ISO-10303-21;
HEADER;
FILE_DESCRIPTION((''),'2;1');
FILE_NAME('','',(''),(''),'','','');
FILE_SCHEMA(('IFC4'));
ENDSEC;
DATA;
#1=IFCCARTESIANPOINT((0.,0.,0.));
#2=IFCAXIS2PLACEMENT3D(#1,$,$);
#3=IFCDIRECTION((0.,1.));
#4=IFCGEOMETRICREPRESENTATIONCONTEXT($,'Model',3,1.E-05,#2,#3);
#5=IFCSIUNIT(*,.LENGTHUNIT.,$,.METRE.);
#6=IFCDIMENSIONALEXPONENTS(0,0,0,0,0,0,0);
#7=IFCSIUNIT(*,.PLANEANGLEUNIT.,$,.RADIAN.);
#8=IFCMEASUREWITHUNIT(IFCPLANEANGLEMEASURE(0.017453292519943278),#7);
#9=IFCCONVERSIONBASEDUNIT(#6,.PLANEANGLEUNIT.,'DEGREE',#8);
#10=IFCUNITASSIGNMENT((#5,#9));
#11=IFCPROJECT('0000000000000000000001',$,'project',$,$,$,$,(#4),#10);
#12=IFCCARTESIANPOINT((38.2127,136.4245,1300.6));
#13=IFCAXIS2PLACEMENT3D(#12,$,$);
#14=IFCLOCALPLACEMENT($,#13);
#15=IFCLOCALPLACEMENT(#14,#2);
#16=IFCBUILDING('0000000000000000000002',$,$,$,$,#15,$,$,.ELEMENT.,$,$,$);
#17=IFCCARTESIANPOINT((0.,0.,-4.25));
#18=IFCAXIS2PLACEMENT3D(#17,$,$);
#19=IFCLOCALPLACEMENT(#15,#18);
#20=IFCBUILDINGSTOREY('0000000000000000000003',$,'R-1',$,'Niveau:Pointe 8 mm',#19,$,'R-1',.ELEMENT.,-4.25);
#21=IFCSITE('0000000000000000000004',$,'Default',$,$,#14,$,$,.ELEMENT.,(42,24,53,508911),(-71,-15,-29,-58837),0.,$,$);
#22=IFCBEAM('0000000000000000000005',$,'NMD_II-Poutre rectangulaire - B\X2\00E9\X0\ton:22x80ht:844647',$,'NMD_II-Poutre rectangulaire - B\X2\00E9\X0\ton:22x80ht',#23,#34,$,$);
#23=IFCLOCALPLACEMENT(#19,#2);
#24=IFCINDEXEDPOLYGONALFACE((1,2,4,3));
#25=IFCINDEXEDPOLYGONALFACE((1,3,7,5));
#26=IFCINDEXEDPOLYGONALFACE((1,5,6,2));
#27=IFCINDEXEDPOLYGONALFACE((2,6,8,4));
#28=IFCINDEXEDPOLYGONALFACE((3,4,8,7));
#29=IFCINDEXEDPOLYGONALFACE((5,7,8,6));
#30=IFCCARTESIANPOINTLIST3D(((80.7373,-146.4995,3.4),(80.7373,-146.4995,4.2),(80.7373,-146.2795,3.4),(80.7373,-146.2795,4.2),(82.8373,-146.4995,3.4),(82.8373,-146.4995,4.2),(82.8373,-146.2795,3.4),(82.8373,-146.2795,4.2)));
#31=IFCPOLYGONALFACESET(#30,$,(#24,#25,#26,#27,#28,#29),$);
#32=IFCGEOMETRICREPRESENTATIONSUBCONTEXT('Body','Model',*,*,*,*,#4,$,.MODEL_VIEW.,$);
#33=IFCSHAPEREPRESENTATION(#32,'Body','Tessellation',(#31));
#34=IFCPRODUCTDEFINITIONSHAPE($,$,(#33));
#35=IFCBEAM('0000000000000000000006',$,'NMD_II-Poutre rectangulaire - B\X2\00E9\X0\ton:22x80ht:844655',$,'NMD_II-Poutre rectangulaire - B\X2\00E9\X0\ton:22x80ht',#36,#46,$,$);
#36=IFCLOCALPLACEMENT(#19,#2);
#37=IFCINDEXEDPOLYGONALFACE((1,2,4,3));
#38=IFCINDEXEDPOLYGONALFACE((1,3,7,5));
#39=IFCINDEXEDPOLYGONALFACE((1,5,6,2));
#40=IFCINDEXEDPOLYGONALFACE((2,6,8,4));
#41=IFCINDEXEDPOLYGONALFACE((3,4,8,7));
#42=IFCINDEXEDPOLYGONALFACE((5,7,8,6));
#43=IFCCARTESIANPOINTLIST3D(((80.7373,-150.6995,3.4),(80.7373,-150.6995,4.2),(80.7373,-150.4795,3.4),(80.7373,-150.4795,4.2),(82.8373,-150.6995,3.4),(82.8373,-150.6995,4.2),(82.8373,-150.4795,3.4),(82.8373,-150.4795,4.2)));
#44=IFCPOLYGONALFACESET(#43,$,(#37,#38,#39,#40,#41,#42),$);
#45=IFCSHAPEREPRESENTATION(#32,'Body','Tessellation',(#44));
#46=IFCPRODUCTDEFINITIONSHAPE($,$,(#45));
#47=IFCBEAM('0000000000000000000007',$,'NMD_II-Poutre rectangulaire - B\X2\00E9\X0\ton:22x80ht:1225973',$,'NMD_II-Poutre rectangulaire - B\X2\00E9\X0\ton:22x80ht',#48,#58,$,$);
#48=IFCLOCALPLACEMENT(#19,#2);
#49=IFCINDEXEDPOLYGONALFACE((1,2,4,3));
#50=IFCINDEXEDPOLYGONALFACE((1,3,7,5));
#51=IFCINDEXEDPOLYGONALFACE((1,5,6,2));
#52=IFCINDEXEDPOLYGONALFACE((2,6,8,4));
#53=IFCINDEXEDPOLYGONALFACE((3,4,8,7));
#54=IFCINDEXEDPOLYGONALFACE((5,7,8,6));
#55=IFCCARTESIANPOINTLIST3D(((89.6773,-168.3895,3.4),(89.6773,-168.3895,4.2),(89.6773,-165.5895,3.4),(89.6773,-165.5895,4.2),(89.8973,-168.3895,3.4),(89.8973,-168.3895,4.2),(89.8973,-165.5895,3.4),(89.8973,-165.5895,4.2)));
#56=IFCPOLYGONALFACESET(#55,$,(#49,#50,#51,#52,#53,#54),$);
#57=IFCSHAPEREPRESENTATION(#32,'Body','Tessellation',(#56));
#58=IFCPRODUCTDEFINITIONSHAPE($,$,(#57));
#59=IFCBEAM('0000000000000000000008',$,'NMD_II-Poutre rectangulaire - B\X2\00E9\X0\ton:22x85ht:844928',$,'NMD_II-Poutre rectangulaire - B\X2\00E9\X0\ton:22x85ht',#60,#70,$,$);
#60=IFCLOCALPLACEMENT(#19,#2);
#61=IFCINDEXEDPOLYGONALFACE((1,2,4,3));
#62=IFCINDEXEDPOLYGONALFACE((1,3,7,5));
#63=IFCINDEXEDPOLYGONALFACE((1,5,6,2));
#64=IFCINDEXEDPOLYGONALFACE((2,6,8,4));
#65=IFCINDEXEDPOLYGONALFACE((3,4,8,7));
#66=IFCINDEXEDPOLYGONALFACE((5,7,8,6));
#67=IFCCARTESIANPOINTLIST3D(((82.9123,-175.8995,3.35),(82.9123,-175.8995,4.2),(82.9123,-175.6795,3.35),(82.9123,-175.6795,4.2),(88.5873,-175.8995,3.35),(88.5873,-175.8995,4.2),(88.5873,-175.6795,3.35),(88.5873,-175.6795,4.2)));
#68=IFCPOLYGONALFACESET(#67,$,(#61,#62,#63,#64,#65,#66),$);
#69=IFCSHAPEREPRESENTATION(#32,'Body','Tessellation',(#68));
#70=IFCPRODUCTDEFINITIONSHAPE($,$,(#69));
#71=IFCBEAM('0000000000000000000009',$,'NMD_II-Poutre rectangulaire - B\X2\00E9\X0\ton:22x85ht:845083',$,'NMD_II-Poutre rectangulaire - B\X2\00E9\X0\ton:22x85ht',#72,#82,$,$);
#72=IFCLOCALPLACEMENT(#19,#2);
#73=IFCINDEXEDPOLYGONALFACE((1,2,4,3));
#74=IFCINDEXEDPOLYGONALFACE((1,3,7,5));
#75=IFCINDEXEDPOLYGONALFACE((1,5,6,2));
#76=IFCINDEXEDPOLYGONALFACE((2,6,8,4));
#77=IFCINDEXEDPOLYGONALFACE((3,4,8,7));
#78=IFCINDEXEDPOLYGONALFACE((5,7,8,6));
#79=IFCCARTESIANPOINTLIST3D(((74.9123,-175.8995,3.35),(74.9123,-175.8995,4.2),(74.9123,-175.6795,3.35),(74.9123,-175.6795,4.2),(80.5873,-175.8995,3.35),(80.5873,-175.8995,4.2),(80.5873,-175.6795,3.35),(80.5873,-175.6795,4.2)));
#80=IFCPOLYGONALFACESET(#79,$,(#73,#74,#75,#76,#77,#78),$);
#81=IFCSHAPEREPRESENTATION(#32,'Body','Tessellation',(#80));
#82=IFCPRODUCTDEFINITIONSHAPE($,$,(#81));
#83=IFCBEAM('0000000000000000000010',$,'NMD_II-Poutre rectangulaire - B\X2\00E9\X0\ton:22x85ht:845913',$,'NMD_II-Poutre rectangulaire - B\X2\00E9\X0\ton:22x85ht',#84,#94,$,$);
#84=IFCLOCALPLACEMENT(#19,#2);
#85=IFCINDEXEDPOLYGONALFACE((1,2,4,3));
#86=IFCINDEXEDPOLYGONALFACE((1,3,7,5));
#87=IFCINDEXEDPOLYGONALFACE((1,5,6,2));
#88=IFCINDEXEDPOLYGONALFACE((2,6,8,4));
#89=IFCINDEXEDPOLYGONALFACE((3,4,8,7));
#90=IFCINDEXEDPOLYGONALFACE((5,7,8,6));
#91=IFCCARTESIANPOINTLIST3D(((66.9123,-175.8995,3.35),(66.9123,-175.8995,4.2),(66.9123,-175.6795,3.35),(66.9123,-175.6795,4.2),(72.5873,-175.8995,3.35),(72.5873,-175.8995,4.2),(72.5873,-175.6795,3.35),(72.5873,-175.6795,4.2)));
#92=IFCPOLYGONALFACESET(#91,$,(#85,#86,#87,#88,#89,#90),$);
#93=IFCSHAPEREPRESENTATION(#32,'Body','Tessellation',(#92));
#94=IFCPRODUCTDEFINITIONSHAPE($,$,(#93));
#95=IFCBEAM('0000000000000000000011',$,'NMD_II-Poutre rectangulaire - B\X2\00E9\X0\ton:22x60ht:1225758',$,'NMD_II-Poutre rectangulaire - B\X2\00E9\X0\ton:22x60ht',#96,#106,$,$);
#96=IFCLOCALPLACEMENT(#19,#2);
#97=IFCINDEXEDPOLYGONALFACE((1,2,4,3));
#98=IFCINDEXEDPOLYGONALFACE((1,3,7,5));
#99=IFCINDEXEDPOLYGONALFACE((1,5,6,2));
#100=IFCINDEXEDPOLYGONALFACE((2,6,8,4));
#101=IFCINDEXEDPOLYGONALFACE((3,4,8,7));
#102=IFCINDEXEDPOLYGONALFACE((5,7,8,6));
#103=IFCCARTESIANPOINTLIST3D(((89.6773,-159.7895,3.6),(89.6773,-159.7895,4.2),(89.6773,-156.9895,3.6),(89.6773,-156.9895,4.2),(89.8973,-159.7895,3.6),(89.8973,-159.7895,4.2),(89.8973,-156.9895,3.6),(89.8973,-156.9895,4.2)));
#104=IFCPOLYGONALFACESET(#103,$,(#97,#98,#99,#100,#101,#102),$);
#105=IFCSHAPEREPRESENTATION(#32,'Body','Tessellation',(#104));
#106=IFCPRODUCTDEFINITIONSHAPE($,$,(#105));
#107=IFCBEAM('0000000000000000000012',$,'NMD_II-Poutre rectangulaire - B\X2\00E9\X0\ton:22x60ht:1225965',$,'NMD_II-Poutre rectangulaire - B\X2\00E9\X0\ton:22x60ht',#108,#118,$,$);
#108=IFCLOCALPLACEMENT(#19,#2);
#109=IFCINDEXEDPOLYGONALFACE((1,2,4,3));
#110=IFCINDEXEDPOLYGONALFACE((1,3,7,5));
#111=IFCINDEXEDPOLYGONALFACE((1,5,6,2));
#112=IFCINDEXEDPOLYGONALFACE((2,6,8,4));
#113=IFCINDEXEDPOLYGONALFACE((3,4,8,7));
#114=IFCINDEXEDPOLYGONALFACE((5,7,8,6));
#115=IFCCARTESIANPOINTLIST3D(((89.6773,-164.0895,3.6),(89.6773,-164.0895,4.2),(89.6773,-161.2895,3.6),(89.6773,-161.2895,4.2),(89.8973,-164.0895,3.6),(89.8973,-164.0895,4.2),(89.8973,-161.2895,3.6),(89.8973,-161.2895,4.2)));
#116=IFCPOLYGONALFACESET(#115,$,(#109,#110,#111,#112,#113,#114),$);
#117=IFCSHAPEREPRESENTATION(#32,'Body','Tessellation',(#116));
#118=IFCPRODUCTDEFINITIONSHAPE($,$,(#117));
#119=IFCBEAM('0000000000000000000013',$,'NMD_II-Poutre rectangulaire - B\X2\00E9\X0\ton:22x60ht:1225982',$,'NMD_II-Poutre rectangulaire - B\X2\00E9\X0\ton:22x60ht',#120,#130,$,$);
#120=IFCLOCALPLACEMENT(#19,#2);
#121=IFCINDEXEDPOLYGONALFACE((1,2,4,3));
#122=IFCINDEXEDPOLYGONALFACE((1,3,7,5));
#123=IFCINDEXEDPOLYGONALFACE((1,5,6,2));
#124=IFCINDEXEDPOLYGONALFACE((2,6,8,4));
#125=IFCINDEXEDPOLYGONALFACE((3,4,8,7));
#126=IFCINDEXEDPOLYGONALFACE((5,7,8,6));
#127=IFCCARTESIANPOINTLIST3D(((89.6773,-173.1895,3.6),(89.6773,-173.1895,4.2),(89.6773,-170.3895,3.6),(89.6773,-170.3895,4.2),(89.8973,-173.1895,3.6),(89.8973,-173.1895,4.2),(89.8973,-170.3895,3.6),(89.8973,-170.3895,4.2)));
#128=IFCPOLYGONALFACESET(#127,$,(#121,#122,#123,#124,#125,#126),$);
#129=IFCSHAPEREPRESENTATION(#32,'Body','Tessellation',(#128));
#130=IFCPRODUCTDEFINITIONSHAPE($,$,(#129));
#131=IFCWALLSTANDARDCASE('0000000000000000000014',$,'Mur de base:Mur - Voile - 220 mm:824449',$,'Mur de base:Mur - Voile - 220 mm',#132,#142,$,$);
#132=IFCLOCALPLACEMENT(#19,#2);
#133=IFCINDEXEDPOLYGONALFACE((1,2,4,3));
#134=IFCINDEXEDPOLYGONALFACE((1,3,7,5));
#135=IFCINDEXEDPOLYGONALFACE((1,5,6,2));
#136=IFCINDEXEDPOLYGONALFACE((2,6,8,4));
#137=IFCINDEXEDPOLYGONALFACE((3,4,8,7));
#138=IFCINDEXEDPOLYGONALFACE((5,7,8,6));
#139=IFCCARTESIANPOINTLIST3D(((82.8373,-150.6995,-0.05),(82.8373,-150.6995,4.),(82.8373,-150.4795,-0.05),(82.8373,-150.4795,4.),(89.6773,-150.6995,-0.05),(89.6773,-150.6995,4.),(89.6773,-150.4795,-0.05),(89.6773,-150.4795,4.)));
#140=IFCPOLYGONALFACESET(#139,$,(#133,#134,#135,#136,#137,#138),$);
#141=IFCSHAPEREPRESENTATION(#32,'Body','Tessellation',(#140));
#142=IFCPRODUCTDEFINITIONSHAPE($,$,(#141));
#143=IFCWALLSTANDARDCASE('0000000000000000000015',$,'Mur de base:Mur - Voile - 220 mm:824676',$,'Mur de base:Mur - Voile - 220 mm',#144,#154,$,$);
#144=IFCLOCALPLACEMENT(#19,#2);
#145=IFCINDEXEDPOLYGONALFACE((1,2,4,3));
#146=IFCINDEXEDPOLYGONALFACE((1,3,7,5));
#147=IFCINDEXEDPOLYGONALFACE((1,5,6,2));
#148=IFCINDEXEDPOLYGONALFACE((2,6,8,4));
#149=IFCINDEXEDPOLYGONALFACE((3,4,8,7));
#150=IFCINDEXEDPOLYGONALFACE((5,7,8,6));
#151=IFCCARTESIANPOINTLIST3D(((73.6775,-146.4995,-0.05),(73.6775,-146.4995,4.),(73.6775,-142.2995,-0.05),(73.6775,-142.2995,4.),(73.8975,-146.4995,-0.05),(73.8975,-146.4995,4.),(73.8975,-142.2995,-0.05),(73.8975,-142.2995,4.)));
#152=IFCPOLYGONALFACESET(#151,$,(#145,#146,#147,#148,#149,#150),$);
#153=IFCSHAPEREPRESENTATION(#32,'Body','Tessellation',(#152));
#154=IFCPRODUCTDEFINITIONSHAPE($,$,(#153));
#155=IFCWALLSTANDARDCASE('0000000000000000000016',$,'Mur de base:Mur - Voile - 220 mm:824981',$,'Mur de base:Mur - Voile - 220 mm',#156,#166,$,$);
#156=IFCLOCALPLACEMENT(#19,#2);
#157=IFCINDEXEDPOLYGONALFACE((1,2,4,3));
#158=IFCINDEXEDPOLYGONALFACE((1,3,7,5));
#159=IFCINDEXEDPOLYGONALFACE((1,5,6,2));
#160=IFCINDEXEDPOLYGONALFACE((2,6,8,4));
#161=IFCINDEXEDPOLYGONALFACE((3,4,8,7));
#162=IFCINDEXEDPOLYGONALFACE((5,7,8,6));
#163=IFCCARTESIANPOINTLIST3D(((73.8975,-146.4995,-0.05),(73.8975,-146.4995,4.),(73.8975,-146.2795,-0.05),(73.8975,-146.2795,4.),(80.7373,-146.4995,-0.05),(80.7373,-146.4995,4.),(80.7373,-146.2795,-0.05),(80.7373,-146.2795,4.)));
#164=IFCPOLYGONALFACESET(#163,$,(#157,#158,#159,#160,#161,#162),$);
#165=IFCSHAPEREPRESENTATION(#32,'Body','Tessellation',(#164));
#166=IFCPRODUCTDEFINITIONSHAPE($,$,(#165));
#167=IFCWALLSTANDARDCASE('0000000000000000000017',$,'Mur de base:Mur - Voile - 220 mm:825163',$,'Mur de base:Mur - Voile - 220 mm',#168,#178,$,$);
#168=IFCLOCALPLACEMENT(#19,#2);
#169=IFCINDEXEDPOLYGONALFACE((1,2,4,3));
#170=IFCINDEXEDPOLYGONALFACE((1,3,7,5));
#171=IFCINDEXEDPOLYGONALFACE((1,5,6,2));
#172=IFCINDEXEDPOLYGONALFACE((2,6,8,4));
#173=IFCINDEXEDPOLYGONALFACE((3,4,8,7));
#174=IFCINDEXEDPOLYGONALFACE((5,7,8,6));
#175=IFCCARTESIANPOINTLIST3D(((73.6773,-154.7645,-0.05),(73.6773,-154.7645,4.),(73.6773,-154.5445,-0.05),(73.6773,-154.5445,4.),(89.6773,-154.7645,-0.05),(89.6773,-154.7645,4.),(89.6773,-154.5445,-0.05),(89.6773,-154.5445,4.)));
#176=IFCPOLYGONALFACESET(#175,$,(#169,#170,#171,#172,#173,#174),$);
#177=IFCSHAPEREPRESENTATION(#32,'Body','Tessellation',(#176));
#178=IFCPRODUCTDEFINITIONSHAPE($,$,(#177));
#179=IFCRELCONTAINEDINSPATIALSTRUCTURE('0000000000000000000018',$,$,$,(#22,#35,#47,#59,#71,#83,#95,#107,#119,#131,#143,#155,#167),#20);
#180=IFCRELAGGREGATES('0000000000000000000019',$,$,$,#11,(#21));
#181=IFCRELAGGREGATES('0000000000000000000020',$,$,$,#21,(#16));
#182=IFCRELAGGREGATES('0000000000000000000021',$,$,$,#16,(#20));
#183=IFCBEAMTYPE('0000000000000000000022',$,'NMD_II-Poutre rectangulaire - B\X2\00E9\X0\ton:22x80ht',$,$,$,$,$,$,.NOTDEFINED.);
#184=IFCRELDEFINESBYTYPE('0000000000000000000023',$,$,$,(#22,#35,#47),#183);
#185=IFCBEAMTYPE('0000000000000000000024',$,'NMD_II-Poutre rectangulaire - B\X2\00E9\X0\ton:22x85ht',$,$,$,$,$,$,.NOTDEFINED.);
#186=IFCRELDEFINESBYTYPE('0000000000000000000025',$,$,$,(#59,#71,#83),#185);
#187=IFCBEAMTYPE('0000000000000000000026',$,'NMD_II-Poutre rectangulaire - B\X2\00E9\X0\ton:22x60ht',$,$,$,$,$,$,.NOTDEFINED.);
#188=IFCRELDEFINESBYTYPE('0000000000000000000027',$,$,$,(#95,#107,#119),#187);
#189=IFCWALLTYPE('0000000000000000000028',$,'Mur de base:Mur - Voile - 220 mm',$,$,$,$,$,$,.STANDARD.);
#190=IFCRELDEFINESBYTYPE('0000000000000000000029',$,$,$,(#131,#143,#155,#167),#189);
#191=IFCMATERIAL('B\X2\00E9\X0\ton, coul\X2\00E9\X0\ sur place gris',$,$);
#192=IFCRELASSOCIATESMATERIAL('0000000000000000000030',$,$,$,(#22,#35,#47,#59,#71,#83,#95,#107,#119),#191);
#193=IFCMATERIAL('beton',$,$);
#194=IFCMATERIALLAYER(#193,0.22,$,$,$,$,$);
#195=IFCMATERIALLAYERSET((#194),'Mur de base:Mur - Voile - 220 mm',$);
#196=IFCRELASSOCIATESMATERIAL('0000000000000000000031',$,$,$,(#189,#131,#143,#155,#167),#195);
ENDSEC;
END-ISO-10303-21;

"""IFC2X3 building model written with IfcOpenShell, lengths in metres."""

from ifc_helpers import new_model, entity, si_unit, converted_unit, direction, frame, frame_2d, origin, origin_2d_with_axis, place, context, subcontext, project, spatial, polyline, rectangle, extrude, clip, bounded_halfspace, material, layer, layer_set, layer_usage, type_object, element, save


model = new_model("IFC2X3")

# Units and contexts
model_context = context("Model", 3, precision=1e-05, world=origin(), true_north=direction((0.0, 1.0)))
body_context = subcontext(model_context, "Body", "Model", "MODEL_VIEW")
ifc_project = project(units=[si_unit("LENGTHUNIT", "METRE"), converted_unit("PLANEANGLEUNIT", "DEGREE", entity("IfcPlaneAngleMeasure", 0.017453292519943278), si_unit("PLANEANGLEUNIT", "RADIAN"), dimensions=[0, 0, 0, 0, 0, 0, 0])], contexts=[model_context])

# Site, building, storey
site_placement = place(None, frame((38.2127, 136.4245, 1300.6)))
site = spatial("IfcSite", under=ifc_project, at=site_placement, Name="Default", CompositionType="ELEMENT", RefLatitude=(42, 24, 53, 508911), RefLongitude=(-71, -15, -29, -58837), RefElevation=0.0)
building_placement = place(site_placement, origin())
building = spatial("IfcBuilding", under=site, at=building_placement, CompositionType="ELEMENT")
storey_placement = place(building_placement, frame((0.0, 0.0, -4.25)))
storey = spatial("IfcBuildingStorey", under=building, at=storey_placement, Name="R-1", ObjectType="Niveau:Pointe 8 mm", LongName="R-1", CompositionType="ELEMENT", Elevation=-4.25)

# Beams
ifc_material_1 = material(Name="Béton, coulé sur place gris")
beam_type_1 = type_object("IfcBeamType", Name="NMD_II-Poutre rectangulaire - Béton:22x80ht", PredefinedType="NOTDEFINED")
for number, where, name in (
    (1, (80.7373, -146.3895, 4.2), "NMD_II-Poutre rectangulaire - Béton:22x80ht:844647"),
    (2, (80.7373, -150.5895, 4.2), "NMD_II-Poutre rectangulaire - Béton:22x80ht:844655"),
):
    element("IfcBeam", number, at=place(storey_placement, frame(where)), inside=storey, type_object=beam_type_1, material=ifc_material_1, Name=name, ObjectType="NMD_II-Poutre rectangulaire - Béton:22x80ht", context=body_context, shape_type="SweptSolid", body=[
        extrude(rectangle(XDim=0.8, YDim=0.22, at=origin_2d_with_axis()), frame((0.0, 0.0, -0.4), z_axis=(1.0, 0.0, 0.0), x_axis=(0.0, 0.0, -1.0)), (0.0, 0.0, 1.0), 2.1),
    ])
beam_1_placement = place(storey_placement, frame((89.7873, -168.3895, 4.2), z_axis=(0.0, 0.0, 1.0), x_axis=(0.0, 1.0, 0.0)))
element("IfcBeam", 3, at=beam_1_placement, inside=storey, type_object=beam_type_1, material=ifc_material_1, Name="NMD_II-Poutre rectangulaire - Béton:22x80ht:1225973", ObjectType="NMD_II-Poutre rectangulaire - Béton:22x80ht", context=body_context, shape_type="SweptSolid", body=[
    extrude(rectangle(XDim=0.8, YDim=0.22, at=frame_2d((0.0, 0.0), x_axis=(1.0, 0.0))), frame((0.0, 0.0, -0.4), z_axis=(1.0, 0.0, 0.0), x_axis=(0.0, 0.0, -1.0)), (0.0, 0.0, 1.0), 2.8),
])
beam_type_2 = type_object("IfcBeamType", Name="NMD_II-Poutre rectangulaire - Béton:22x85ht", PredefinedType="NOTDEFINED")
beam_2_placement = place(storey_placement, frame((82.9123, -175.7895, 4.2)))
element("IfcBeam", 4, at=beam_2_placement, inside=storey, type_object=beam_type_2, material=ifc_material_1, Name="NMD_II-Poutre rectangulaire - Béton:22x85ht:844928", ObjectType="NMD_II-Poutre rectangulaire - Béton:22x85ht", context=body_context, shape_type="SweptSolid", body=[
    extrude(rectangle(XDim=0.85, YDim=0.22, at=frame_2d((0.0, 0.0), x_axis=(1.0, 0.0))), frame((0.0, 0.0, -0.425), z_axis=(1.0, 0.0, 0.0), x_axis=(0.0, 0.0, -1.0)), (0.0, 0.0, 1.0), 5.675),
])
beam_3_placement = place(storey_placement, frame((74.9123, -175.7895, 4.2)))
element("IfcBeam", 5, at=beam_3_placement, inside=storey, type_object=beam_type_2, material=ifc_material_1, Name="NMD_II-Poutre rectangulaire - Béton:22x85ht:845083", ObjectType="NMD_II-Poutre rectangulaire - Béton:22x85ht", context=body_context, shape_type="SweptSolid", body=[
    extrude(rectangle(XDim=0.85, YDim=0.22, at=frame_2d((0.0, 0.0), x_axis=(1.0, 0.0))), frame((0.0, 0.0, -0.425), z_axis=(1.0, 0.0, 0.0), x_axis=(0.0, 0.0, -1.0)), (0.0, 0.0, 1.0), 5.675),
])
beam_4_placement = place(storey_placement, frame((66.9123, -175.7895, 4.2)))
element("IfcBeam", 6, at=beam_4_placement, inside=storey, type_object=beam_type_2, material=ifc_material_1, Name="NMD_II-Poutre rectangulaire - Béton:22x85ht:845913", ObjectType="NMD_II-Poutre rectangulaire - Béton:22x85ht", context=body_context, shape_type="SweptSolid", body=[
    extrude(rectangle(XDim=0.85, YDim=0.22, at=frame_2d((0.0, 0.0), x_axis=(1.0, 0.0))), frame((0.0, 0.0, -0.425), z_axis=(1.0, 0.0, 0.0), x_axis=(0.0, 0.0, -1.0)), (0.0, 0.0, 1.0), 5.675),
])
beam_type_3 = type_object("IfcBeamType", Name="NMD_II-Poutre rectangulaire - Béton:22x60ht", PredefinedType="NOTDEFINED")
beam_5_placement = place(storey_placement, frame((89.7873, -159.7895, 4.2), z_axis=(0.0, 0.0, 1.0), x_axis=(0.0, 1.0, 0.0)))
element("IfcBeam", 7, at=beam_5_placement, inside=storey, type_object=beam_type_3, material=ifc_material_1, Name="NMD_II-Poutre rectangulaire - Béton:22x60ht:1225758", ObjectType="NMD_II-Poutre rectangulaire - Béton:22x60ht", context=body_context, shape_type="SweptSolid", body=[
    extrude(rectangle(XDim=0.6, YDim=0.22, at=frame_2d((0.0, 0.0), x_axis=(1.0, 0.0))), frame((0.0, 0.0, -0.3), z_axis=(1.0, 0.0, 0.0), x_axis=(0.0, 0.0, -1.0)), (0.0, 0.0, 1.0), 2.8),
])
beam_6_placement = place(storey_placement, frame((89.7873, -164.0895, 4.2), z_axis=(0.0, 0.0, 1.0), x_axis=(0.0, 1.0, 0.0)))
element("IfcBeam", 8, at=beam_6_placement, inside=storey, type_object=beam_type_3, material=ifc_material_1, Name="NMD_II-Poutre rectangulaire - Béton:22x60ht:1225965", ObjectType="NMD_II-Poutre rectangulaire - Béton:22x60ht", context=body_context, shape_type="SweptSolid", body=[
    extrude(rectangle(XDim=0.6, YDim=0.22, at=frame_2d((0.0, 0.0), x_axis=(1.0, 0.0))), frame((0.0, 0.0, -0.3), z_axis=(1.0, 0.0, 0.0), x_axis=(0.0, 0.0, -1.0)), (0.0, 0.0, 1.0), 2.8),
])
beam_7_placement = place(storey_placement, frame((89.7873, -173.1895, 4.2), z_axis=(0.0, 0.0, 1.0), x_axis=(0.0, 1.0, 0.0)))
element("IfcBeam", 9, at=beam_7_placement, inside=storey, type_object=beam_type_3, material=ifc_material_1, Name="NMD_II-Poutre rectangulaire - Béton:22x60ht:1225982", ObjectType="NMD_II-Poutre rectangulaire - Béton:22x60ht", context=body_context, shape_type="SweptSolid", body=[
    extrude(rectangle(XDim=0.6, YDim=0.22, at=frame_2d((0.0, 0.0), x_axis=(1.0, 0.0))), frame((0.0, 0.0, -0.3), z_axis=(1.0, 0.0, 0.0), x_axis=(0.0, 0.0, -1.0)), (0.0, 0.0, 1.0), 2.8),
])

# Walls
ifc_material_2 = material(Name="beton")
ifc_layer = layer(ifc_material_2, 0.22)
ifc_layer_set = layer_set([ifc_layer], Name="Mur de base:Mur - Voile - 220 mm")
wall_type = type_object("IfcWallType", Name="Mur de base:Mur - Voile - 220 mm", PredefinedType="STANDARD", material=ifc_layer_set)
ifc_layer_usage_1 = layer_usage(ifc_layer_set, "AXIS2", "NEGATIVE", 0.11)
wall_1_placement = place(storey_placement, frame((89.6773, -150.5895, -0.05), z_axis=(0.0, 0.0, 1.0), x_axis=(-1.0, 0.0, 0.0)))
element("IfcWallStandardCase", 10, at=wall_1_placement, inside=storey, type_object=wall_type, material=ifc_layer_usage_1, Name="Mur de base:Mur - Voile - 220 mm:824449", ObjectType="Mur de base:Mur - Voile - 220 mm", context=body_context, shape_type="Clipping", body=[
    clip(extrude(rectangle(XDim=6.84, YDim=0.22, at=frame_2d((3.42, 0.0), x_axis=(-1.0, 0.0))), origin(), (0.0, 0.0, 1.0), 4.05), bounded_halfspace(frame((0.0, -0.11, 4.05), z_axis=(0.0, 0.0, -1.0), x_axis=(0.0, 1.0, 0.0)), True, frame((0.0, -0.11, 4.05)), polyline([(0.0, 0.0), (6.84, 0.0), (6.84, 0.22), (0.0, 0.22), (0.0, 0.0)]))),
])
ifc_layer_usage_2 = layer_usage(ifc_layer_set, "AXIS2", "NEGATIVE", 0.11)
wall_2_placement = place(storey_placement, frame((73.7875, -142.2995, -0.05), z_axis=(0.0, 0.0, 1.0), x_axis=(0.0, -1.0, 0.0)))
element("IfcWallStandardCase", 11, at=wall_2_placement, inside=storey, type_object=wall_type, material=ifc_layer_usage_2, Name="Mur de base:Mur - Voile - 220 mm:824676", ObjectType="Mur de base:Mur - Voile - 220 mm", context=body_context, shape_type="SweptSolid", body=[
    extrude(rectangle(XDim=4.2, YDim=0.22, at=frame_2d((2.1, 0.0), x_axis=(-1.0, 0.0))), origin(), (0.0, 0.0, 1.0), 4.05),
])
ifc_layer_usage_3 = layer_usage(ifc_layer_set, "AXIS2", "NEGATIVE", 0.11)
wall_3_placement = place(storey_placement, frame((73.8975, -146.3895, -0.05)))
element("IfcWallStandardCase", 12, at=wall_3_placement, inside=storey, type_object=wall_type, material=ifc_layer_usage_3, Name="Mur de base:Mur - Voile - 220 mm:824981", ObjectType="Mur de base:Mur - Voile - 220 mm", context=body_context, shape_type="Clipping", body=[
    clip(extrude(rectangle(XDim=6.8398, YDim=0.22, at=frame_2d((3.4199, 0.0), x_axis=(-1.0, 0.0))), origin(), (0.0, 0.0, 1.0), 4.05), bounded_halfspace(frame((0.0, -0.11, 4.05), z_axis=(0.0, 0.0, -1.0), x_axis=(0.0, -1.0, 0.0)), True, frame((0.0, -0.11, 4.05)), polyline([(0.0, 0.0), (6.8398, 0.0), (6.8398, 0.22), (0.0, 0.22), (0.0, 0.0)]))),
])
ifc_layer_usage_4 = layer_usage(ifc_layer_set, "AXIS2", "NEGATIVE", 0.11)
wall_4_placement = place(storey_placement, frame((73.6773, -154.6545, -0.05)))
element("IfcWallStandardCase", 13, at=wall_4_placement, inside=storey, type_object=wall_type, material=ifc_layer_usage_4, Name="Mur de base:Mur - Voile - 220 mm:825163", ObjectType="Mur de base:Mur - Voile - 220 mm", context=body_context, shape_type="Clipping", body=[
    clip(extrude(rectangle(XDim=16.0, YDim=0.22, at=frame_2d((8.0, 0.0), x_axis=(-1.0, 0.0))), origin(), (0.0, 0.0, 1.0), 4.05), bounded_halfspace(frame((0.0, -0.11, 4.05), z_axis=(0.0, 0.0, -1.0), x_axis=(0.0, -1.0, 0.0)), True, frame((0.0, -0.11, 4.05)), polyline([(0.0, 0.0), (16.0, 0.0), (16.0, 0.22), (0.22, 0.22), (0.0, 0.22), (0.0, 0.0)]))),
])

save(model, "model.ifc")
